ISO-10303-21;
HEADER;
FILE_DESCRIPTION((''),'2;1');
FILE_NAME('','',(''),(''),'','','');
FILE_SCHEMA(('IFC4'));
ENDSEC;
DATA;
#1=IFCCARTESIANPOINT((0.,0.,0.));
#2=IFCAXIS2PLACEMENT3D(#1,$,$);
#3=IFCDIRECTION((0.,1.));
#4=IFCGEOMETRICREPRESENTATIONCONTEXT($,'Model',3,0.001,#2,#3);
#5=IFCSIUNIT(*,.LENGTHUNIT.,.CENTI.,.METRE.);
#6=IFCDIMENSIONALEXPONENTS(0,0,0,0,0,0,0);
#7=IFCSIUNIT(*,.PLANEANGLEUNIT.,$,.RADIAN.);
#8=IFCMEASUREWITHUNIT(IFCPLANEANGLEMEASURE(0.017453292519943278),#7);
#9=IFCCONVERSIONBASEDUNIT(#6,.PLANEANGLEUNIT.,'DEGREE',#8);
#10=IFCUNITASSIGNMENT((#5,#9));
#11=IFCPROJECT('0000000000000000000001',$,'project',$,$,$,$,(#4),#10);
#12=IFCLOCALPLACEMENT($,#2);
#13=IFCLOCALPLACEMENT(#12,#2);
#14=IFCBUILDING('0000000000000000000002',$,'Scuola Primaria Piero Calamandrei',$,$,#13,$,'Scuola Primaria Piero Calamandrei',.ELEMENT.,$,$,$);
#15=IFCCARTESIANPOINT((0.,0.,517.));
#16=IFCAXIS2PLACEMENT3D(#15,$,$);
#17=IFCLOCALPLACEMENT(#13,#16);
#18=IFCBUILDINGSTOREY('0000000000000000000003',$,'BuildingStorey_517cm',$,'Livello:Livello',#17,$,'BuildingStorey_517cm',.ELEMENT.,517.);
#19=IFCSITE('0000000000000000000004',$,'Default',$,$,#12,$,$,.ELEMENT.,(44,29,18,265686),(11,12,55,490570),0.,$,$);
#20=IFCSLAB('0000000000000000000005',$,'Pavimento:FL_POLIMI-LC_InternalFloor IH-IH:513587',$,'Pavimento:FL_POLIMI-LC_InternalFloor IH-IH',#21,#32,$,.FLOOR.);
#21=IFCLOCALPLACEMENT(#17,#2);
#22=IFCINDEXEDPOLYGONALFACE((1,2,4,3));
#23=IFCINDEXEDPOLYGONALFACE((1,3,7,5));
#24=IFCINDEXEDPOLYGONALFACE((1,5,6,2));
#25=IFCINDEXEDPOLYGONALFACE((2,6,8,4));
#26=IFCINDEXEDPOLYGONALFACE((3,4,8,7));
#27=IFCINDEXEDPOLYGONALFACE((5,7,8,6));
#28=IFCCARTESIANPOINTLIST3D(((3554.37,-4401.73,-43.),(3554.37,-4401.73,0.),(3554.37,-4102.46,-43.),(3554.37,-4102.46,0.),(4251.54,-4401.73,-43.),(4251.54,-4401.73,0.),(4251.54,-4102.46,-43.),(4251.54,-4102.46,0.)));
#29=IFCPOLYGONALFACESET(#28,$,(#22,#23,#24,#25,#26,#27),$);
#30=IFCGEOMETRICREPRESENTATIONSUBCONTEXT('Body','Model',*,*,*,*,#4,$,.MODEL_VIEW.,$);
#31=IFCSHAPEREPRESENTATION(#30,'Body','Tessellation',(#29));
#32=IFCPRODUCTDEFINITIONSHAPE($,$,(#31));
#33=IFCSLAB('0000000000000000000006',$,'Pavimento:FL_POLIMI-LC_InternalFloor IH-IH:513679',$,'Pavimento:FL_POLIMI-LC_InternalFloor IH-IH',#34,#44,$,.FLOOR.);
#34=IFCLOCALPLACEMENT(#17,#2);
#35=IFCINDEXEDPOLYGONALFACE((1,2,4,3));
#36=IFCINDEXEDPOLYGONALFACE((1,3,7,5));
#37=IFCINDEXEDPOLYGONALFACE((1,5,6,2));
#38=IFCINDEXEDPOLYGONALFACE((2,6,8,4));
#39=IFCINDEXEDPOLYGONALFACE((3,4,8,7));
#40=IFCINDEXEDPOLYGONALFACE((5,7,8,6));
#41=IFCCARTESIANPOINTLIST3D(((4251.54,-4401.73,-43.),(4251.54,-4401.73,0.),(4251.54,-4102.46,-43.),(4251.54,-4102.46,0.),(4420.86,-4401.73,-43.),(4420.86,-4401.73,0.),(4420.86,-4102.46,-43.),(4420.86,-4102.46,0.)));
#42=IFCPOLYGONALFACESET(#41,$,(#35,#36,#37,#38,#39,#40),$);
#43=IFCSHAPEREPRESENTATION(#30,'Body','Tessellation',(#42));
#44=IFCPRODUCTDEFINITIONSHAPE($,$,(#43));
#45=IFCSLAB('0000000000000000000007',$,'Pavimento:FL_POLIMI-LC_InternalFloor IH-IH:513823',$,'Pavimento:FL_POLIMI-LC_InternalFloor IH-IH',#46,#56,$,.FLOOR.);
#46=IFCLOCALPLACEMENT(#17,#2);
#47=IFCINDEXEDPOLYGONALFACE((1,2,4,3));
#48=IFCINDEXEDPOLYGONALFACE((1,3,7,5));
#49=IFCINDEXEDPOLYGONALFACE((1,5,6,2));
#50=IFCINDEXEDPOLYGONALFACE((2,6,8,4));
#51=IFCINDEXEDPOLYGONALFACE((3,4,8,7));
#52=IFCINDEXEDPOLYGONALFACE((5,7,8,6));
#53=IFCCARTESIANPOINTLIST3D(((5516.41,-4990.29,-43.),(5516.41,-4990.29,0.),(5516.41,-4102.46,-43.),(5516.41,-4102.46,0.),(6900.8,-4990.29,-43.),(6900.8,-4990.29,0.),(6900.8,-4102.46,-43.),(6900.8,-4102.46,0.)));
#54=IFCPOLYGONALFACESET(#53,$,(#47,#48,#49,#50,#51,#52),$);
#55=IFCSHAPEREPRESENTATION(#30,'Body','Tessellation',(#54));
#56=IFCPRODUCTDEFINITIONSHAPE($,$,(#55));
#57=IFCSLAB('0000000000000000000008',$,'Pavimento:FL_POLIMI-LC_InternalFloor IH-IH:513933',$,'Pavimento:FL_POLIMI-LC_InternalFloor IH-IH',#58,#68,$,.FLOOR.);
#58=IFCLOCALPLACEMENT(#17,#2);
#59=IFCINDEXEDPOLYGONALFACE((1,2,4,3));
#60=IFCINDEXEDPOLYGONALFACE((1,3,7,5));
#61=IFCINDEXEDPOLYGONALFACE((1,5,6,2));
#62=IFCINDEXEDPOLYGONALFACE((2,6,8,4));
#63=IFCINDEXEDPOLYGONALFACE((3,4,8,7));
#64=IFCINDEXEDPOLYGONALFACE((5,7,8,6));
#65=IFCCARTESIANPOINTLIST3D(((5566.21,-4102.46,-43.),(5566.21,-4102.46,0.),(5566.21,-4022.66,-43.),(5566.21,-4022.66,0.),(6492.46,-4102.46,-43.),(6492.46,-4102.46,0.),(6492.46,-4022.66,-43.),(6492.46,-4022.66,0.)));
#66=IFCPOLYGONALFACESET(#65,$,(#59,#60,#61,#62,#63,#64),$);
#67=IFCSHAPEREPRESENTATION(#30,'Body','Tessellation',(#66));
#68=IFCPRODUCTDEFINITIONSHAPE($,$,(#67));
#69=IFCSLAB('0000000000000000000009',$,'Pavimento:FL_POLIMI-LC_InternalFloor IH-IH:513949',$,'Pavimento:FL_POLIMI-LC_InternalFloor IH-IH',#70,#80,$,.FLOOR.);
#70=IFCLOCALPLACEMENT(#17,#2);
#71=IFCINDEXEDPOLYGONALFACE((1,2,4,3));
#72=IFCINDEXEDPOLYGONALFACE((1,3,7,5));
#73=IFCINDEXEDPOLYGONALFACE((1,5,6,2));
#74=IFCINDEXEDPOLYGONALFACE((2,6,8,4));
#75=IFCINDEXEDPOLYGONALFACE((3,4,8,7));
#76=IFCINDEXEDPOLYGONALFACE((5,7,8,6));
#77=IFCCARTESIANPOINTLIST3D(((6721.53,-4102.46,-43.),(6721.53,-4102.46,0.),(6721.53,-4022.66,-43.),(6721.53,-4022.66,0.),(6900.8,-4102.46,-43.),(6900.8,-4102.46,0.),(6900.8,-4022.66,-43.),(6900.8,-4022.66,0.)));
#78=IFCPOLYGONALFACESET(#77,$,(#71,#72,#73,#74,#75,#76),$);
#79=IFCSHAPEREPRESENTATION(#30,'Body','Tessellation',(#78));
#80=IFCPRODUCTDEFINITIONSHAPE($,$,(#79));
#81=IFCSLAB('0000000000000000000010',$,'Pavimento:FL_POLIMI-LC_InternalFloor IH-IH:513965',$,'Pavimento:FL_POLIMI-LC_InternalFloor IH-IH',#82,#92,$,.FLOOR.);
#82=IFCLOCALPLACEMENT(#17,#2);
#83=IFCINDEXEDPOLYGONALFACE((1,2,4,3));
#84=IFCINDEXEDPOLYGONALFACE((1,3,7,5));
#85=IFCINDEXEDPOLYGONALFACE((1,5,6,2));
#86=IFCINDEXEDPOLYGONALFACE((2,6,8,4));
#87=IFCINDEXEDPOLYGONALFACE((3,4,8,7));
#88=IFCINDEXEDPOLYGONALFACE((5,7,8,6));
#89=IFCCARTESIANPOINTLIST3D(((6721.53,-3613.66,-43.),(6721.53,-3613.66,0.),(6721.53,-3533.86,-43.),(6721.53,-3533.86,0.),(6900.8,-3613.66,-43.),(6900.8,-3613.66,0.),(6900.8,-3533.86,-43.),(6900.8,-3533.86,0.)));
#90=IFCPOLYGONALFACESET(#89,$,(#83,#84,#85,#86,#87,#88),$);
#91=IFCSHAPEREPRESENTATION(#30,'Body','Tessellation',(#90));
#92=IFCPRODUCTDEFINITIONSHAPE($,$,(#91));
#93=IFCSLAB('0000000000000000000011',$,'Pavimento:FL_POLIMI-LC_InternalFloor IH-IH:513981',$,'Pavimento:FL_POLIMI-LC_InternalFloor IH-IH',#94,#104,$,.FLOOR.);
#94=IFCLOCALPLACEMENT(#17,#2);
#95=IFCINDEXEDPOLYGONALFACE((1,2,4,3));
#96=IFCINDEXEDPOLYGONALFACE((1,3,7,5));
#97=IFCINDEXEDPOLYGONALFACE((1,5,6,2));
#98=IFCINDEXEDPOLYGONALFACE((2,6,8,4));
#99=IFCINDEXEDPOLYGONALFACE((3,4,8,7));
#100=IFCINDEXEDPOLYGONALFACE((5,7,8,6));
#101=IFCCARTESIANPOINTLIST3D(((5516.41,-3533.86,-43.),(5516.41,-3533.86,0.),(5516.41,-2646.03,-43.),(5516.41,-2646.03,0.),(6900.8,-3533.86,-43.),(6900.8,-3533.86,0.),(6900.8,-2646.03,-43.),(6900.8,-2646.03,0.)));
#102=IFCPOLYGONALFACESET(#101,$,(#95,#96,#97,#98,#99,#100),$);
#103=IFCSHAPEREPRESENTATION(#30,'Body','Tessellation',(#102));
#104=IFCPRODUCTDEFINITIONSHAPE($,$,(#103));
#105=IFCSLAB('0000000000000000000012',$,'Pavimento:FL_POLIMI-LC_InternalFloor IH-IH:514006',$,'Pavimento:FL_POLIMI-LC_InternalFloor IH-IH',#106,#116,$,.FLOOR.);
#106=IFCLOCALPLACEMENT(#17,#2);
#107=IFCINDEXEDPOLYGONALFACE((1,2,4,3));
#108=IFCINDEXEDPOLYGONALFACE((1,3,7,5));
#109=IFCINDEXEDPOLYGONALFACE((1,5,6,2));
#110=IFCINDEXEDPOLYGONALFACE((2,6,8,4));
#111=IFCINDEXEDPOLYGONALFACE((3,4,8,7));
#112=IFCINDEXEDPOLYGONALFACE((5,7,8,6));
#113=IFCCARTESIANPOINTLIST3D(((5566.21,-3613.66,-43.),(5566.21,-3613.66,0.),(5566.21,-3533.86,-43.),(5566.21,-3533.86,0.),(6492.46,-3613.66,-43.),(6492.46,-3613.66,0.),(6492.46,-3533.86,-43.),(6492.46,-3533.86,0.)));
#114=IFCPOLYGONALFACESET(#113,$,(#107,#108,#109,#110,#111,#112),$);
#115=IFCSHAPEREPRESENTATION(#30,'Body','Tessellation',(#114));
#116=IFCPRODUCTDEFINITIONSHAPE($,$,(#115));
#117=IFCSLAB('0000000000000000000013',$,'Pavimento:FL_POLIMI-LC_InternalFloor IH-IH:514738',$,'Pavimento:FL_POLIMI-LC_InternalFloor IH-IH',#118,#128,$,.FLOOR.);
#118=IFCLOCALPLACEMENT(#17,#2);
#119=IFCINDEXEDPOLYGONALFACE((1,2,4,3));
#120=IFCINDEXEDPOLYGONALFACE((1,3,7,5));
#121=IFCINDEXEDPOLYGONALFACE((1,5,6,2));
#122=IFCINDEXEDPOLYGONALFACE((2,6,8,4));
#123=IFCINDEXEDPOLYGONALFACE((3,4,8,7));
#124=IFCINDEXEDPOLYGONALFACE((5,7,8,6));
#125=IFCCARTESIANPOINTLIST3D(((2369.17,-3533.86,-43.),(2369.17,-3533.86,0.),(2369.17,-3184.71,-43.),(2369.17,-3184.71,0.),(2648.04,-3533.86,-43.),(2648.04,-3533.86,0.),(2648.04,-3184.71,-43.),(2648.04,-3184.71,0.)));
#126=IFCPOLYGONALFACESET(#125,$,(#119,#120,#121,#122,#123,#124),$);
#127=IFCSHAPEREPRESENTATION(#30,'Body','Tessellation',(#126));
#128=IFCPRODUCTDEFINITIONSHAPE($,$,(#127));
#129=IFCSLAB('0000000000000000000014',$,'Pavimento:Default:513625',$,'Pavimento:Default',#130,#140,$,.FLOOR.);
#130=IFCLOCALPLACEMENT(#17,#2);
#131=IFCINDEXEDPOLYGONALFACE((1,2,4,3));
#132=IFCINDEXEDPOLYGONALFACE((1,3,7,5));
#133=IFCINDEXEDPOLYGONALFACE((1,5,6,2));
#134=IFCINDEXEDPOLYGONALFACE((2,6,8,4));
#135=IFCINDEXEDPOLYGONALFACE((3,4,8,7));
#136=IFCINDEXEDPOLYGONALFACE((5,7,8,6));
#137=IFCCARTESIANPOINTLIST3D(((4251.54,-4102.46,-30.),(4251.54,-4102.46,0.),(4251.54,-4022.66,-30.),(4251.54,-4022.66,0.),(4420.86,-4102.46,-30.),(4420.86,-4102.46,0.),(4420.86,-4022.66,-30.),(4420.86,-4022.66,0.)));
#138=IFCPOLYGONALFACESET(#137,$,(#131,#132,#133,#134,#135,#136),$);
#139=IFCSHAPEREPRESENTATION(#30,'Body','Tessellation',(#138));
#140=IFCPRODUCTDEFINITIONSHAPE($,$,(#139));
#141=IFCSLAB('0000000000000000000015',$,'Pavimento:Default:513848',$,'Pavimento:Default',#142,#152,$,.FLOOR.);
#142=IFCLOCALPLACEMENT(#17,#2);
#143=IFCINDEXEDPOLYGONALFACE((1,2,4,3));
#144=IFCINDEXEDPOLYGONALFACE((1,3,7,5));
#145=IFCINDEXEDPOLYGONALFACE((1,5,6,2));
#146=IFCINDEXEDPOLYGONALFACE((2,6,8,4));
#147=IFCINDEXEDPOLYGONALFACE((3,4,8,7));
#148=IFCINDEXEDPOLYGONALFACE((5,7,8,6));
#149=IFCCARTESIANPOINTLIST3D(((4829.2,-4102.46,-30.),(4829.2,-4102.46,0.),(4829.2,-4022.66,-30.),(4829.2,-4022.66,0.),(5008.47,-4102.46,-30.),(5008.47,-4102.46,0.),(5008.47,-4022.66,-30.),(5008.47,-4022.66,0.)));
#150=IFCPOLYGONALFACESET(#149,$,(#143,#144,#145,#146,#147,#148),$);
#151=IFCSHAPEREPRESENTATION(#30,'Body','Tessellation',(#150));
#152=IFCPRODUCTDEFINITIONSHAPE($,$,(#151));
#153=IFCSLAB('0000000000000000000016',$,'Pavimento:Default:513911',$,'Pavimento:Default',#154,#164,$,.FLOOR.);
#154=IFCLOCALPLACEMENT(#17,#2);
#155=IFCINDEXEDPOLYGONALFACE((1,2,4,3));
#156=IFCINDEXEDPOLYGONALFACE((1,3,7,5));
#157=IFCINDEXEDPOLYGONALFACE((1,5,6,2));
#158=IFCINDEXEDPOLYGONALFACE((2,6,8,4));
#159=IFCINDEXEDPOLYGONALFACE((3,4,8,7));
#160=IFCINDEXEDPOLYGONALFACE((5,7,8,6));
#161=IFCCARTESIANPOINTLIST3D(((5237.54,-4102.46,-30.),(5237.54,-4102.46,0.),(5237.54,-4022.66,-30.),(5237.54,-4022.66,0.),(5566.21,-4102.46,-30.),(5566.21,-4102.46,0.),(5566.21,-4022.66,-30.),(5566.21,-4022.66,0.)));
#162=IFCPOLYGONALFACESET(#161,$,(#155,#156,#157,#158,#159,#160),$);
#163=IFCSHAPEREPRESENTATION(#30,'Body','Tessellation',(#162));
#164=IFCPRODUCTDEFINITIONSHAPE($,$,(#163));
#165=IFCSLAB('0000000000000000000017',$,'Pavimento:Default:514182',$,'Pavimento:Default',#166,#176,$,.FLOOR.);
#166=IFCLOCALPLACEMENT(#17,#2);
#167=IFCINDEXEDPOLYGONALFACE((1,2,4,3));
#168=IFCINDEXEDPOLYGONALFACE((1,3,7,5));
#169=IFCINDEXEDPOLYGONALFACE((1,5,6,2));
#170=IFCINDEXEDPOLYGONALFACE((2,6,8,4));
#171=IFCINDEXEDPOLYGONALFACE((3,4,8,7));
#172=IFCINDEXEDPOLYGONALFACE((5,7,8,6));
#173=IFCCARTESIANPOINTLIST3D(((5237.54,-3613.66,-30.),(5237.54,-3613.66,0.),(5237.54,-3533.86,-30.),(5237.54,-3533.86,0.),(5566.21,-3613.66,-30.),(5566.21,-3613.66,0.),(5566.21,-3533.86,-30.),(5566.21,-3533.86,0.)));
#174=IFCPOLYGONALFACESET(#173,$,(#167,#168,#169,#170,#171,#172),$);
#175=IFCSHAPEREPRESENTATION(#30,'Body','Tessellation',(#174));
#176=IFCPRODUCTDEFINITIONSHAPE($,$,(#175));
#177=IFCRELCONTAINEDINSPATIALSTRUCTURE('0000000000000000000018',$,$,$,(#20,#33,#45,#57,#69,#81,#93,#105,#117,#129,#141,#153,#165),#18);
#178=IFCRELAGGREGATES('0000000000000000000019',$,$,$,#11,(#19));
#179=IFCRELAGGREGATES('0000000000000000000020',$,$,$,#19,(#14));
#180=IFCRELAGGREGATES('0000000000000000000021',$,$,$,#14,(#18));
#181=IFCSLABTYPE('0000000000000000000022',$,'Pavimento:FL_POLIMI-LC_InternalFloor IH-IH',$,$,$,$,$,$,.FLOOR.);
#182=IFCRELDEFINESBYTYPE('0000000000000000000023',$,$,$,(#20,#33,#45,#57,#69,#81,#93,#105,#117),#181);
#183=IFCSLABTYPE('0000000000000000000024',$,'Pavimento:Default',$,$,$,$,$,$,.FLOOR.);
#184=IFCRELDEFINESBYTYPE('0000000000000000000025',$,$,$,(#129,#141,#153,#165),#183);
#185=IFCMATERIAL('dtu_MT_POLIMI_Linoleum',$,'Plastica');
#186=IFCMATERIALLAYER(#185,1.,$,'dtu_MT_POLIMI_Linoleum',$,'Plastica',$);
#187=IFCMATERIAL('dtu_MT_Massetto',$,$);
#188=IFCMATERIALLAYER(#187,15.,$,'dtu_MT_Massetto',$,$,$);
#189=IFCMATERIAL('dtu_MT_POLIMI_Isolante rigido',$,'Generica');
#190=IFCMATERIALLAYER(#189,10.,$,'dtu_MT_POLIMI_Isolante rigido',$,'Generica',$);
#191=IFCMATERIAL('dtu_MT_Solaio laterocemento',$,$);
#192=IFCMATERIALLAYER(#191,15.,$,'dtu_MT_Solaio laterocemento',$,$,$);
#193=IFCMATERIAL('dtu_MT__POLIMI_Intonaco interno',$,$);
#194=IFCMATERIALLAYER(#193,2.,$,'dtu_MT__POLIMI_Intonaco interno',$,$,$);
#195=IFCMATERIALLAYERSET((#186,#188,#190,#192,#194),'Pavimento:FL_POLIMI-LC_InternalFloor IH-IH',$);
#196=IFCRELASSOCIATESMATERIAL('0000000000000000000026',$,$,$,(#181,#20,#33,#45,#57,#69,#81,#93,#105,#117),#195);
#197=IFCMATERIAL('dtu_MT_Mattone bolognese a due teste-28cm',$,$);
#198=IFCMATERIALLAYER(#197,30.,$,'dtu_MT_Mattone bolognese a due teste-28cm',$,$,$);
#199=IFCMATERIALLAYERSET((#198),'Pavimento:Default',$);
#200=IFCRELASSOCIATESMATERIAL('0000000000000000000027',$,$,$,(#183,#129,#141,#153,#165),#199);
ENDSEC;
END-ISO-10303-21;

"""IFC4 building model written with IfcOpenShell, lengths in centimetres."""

from ifc_helpers import new_model, entity, si_unit, converted_unit, direction, frame, frame_2d, origin, origin_2d_with_axis, place, context, subcontext, project, spatial, rectangle, extrude, material, layer, layer_set, layer_usage, type_object, element, save


model = new_model("IFC4")

# Units and contexts
model_context = context("Model", 3, precision=0.001, world=origin(), true_north=direction((0.0, 1.0)))
body_context = subcontext(model_context, "Body", "Model", "MODEL_VIEW")
ifc_project = project(units=[si_unit("LENGTHUNIT", "METRE", prefix="CENTI"), converted_unit("PLANEANGLEUNIT", "DEGREE", entity("IfcPlaneAngleMeasure", 0.017453292519943278), si_unit("PLANEANGLEUNIT", "RADIAN"), dimensions=[0, 0, 0, 0, 0, 0, 0])], contexts=[model_context])

# Site, building, storey
site_placement = place(None, origin())
site = spatial("IfcSite", under=ifc_project, at=site_placement, Name="Default", CompositionType="ELEMENT", RefLatitude=(44, 29, 18, 265686), RefLongitude=(11, 12, 55, 490570), RefElevation=0.0)
building_placement = place(site_placement, origin())
building = spatial("IfcBuilding", under=site, at=building_placement, Name="Scuola Primaria Piero Calamandrei", LongName="Scuola Primaria Piero Calamandrei", CompositionType="ELEMENT")
storey_placement = place(building_placement, frame((0.0, 0.0, 517.0)))
storey = spatial("IfcBuildingStorey", under=building, at=storey_placement, Name="BuildingStorey_517cm", ObjectType="Livello:Livello", LongName="BuildingStorey_517cm", CompositionType="ELEMENT", Elevation=517.0)

# Slabs
ifc_material_1 = material(Name="dtu_MT_POLIMI_Linoleum", Category="Plastica")
ifc_layer_1 = layer(ifc_material_1, 1.0, Name="dtu_MT_POLIMI_Linoleum", Category="Plastica")
ifc_material_2 = material(Name="dtu_MT_Massetto")
ifc_layer_2 = layer(ifc_material_2, 15.0, Name="dtu_MT_Massetto")
ifc_material_3 = material(Name="dtu_MT_POLIMI_Isolante rigido", Category="Generica")
ifc_layer_3 = layer(ifc_material_3, 10.0, Name="dtu_MT_POLIMI_Isolante rigido", Category="Generica")
ifc_material_4 = material(Name="dtu_MT_Solaio laterocemento")
ifc_layer_4 = layer(ifc_material_4, 15.0, Name="dtu_MT_Solaio laterocemento")
ifc_material_5 = material(Name="dtu_MT__POLIMI_Intonaco interno")
ifc_layer_5 = layer(ifc_material_5, 2.0, Name="dtu_MT__POLIMI_Intonaco interno")
ifc_layer_set_1 = layer_set([ifc_layer_1, ifc_layer_2, ifc_layer_3, ifc_layer_4, ifc_layer_5], Name="Pavimento:FL_POLIMI-LC_InternalFloor IH-IH")
ifc_layer_usage_1 = layer_usage(ifc_layer_set_1, "AXIS3", "POSITIVE", 0.0)
slab_type_1 = type_object("IfcSlabType", Name="Pavimento:FL_POLIMI-LC_InternalFloor IH-IH", PredefinedType="FLOOR", material=ifc_layer_set_1)
slab_1_placement = place(storey_placement, origin())
element("IfcSlab", 1, at=slab_1_placement, inside=storey, type_object=slab_type_1, material=ifc_layer_usage_1, Name="Pavimento:FL_POLIMI-LC_InternalFloor IH-IH:513587", ObjectType="Pavimento:FL_POLIMI-LC_InternalFloor IH-IH", PredefinedType="FLOOR", context=body_context, shape_type="SweptSolid", body=[
    extrude(rectangle(XDim=299.27, YDim=697.17, at=frame_2d((0.0, 0.0), x_axis=(1.0, 0.0))), frame((3902.96, -4252.1, 0.0), z_axis=(0.0, 0.0, -1.0), x_axis=(0.0, 1.0, 0.0)), (0.0, 0.0, 1.0), 43.0),
])
ifc_layer_usage_2 = layer_usage(ifc_layer_set_1, "AXIS3", "POSITIVE", 0.0)
slab_2_placement = place(storey_placement, origin())
element("IfcSlab", 2, at=slab_2_placement, inside=storey, type_object=slab_type_1, material=ifc_layer_usage_2, Name="Pavimento:FL_POLIMI-LC_InternalFloor IH-IH:513679", ObjectType="Pavimento:FL_POLIMI-LC_InternalFloor IH-IH", PredefinedType="FLOOR", context=body_context, shape_type="SweptSolid", body=[
    extrude(rectangle(XDim=299.27, YDim=169.31, at=origin_2d_with_axis()), frame((4336.2, -4252.1, 0.0), z_axis=(0.0, 0.0, -1.0), x_axis=(0.0, 1.0, 0.0)), (0.0, 0.0, 1.0), 43.0),
])
ifc_layer_usage_3 = layer_usage(ifc_layer_set_1, "AXIS3", "POSITIVE", 0.0)
slab_3_placement = place(storey_placement, origin())
element("IfcSlab", 3, at=slab_3_placement, inside=storey, type_object=slab_type_1, material=ifc_layer_usage_3, Name="Pavimento:FL_POLIMI-LC_InternalFloor IH-IH:513823", ObjectType="Pavimento:FL_POLIMI-LC_InternalFloor IH-IH", PredefinedType="FLOOR", context=body_context, shape_type="SweptSolid", body=[
    extrude(rectangle(XDim=887.82, YDim=1384.39, at=frame_2d((0.0, 0.0), x_axis=(1.0, 0.0))), frame((6208.61, -4546.38, 0.0), z_axis=(0.0, 0.0, -1.0), x_axis=(0.0, 1.0, 0.0)), (0.0, 0.0, 1.0), 43.0),
])
ifc_layer_usage_4 = layer_usage(ifc_layer_set_1, "AXIS3", "POSITIVE", 0.0)
slab_4_placement = place(storey_placement, origin())
element("IfcSlab", 4, at=slab_4_placement, inside=storey, type_object=slab_type_1, material=ifc_layer_usage_4, Name="Pavimento:FL_POLIMI-LC_InternalFloor IH-IH:513933", ObjectType="Pavimento:FL_POLIMI-LC_InternalFloor IH-IH", PredefinedType="FLOOR", context=body_context, shape_type="SweptSolid", body=[
    extrude(rectangle(XDim=79.8, YDim=926.24, at=frame_2d((0.0, 0.0), x_axis=(1.0, 0.0))), frame((6029.33, -4062.56, 0.0), z_axis=(0.0, 0.0, -1.0), x_axis=(0.0, 1.0, 0.0)), (0.0, 0.0, 1.0), 43.0),
])
ifc_layer_usage_5 = layer_usage(ifc_layer_set_1, "AXIS3", "POSITIVE", 0.0)
slab_5_placement = place(storey_placement, origin())
element("IfcSlab", 5, at=slab_5_placement, inside=storey, type_object=slab_type_1, material=ifc_layer_usage_5, Name="Pavimento:FL_POLIMI-LC_InternalFloor IH-IH:513949", ObjectType="Pavimento:FL_POLIMI-LC_InternalFloor IH-IH", PredefinedType="FLOOR", context=body_context, shape_type="SweptSolid", body=[
    extrude(rectangle(XDim=79.8, YDim=179.27, at=frame_2d((0.0, 0.0), x_axis=(1.0, 0.0))), frame((6811.16, -4062.56, 0.0), z_axis=(0.0, 0.0, -1.0), x_axis=(0.0, 1.0, 0.0)), (0.0, 0.0, 1.0), 43.0),
])
ifc_layer_usage_6 = layer_usage(ifc_layer_set_1, "AXIS3", "POSITIVE", 0.0)
slab_6_placement = place(storey_placement, origin())
element("IfcSlab", 6, at=slab_6_placement, inside=storey, type_object=slab_type_1, material=ifc_layer_usage_6, Name="Pavimento:FL_POLIMI-LC_InternalFloor IH-IH:513965", ObjectType="Pavimento:FL_POLIMI-LC_InternalFloor IH-IH", PredefinedType="FLOOR", context=body_context, shape_type="SweptSolid", body=[
    extrude(rectangle(XDim=79.8, YDim=179.27, at=frame_2d((0.0, 0.0), x_axis=(1.0, 0.0))), frame((6811.16, -3573.76, 0.0), z_axis=(0.0, 0.0, -1.0), x_axis=(0.0, 1.0, 0.0)), (0.0, 0.0, 1.0), 43.0),
])
ifc_layer_usage_7 = layer_usage(ifc_layer_set_1, "AXIS3", "POSITIVE", 0.0)
slab_7_placement = place(storey_placement, origin())
element("IfcSlab", 7, at=slab_7_placement, inside=storey, type_object=slab_type_1, material=ifc_layer_usage_7, Name="Pavimento:FL_POLIMI-LC_InternalFloor IH-IH:513981", ObjectType="Pavimento:FL_POLIMI-LC_InternalFloor IH-IH", PredefinedType="FLOOR", context=body_context, shape_type="SweptSolid", body=[
    extrude(rectangle(XDim=887.82, YDim=1384.39, at=frame_2d((0.0, 0.0), x_axis=(1.0, 0.0))), frame((6208.61, -3089.94, 0.0), z_axis=(0.0, 0.0, -1.0), x_axis=(0.0, 1.0, 0.0)), (0.0, 0.0, 1.0), 43.0),
])
ifc_layer_usage_8 = layer_usage(ifc_layer_set_1, "AXIS3", "POSITIVE", 0.0)
slab_8_placement = place(storey_placement, origin())
element("IfcSlab", 8, at=slab_8_placement, inside=storey, type_object=slab_type_1, material=ifc_layer_usage_8, Name="Pavimento:FL_POLIMI-LC_InternalFloor IH-IH:514006", ObjectType="Pavimento:FL_POLIMI-LC_InternalFloor IH-IH", PredefinedType="FLOOR", context=body_context, shape_type="SweptSolid", body=[
    extrude(rectangle(XDim=79.8, YDim=926.24, at=frame_2d((0.0, 0.0), x_axis=(1.0, 0.0))), frame((6029.33, -3573.76, 0.0), z_axis=(0.0, 0.0, -1.0), x_axis=(0.0, 1.0, 0.0)), (0.0, 0.0, 1.0), 43.0),
])
ifc_layer_usage_9 = layer_usage(ifc_layer_set_1, "AXIS3", "POSITIVE", 0.0)
slab_9_placement = place(storey_placement, origin())
element("IfcSlab", 9, at=slab_9_placement, inside=storey, type_object=slab_type_1, material=ifc_layer_usage_9, Name="Pavimento:FL_POLIMI-LC_InternalFloor IH-IH:514738", ObjectType="Pavimento:FL_POLIMI-LC_InternalFloor IH-IH", PredefinedType="FLOOR", context=body_context, shape_type="SweptSolid", body=[
    extrude(rectangle(XDim=349.14, YDim=278.87, at=origin_2d_with_axis()), frame((2508.61, -3359.28, 0.0), z_axis=(0.0, 0.0, -1.0), x_axis=(0.0, 1.0, 0.0)), (0.0, 0.0, 1.0), 43.0),
])
ifc_material_6 = material(Name="dtu_MT_Mattone bolognese a due teste-28cm")
ifc_layer_6 = layer(ifc_material_6, 30.0, Name="dtu_MT_Mattone bolognese a due teste-28cm")
ifc_layer_set_2 = layer_set([ifc_layer_6], Name="Pavimento:Default")
ifc_layer_usage_10 = layer_usage(ifc_layer_set_2, "AXIS3", "POSITIVE", 0.0)
slab_type_2 = type_object("IfcSlabType", Name="Pavimento:Default", PredefinedType="FLOOR", material=ifc_layer_set_2)
slab_10_placement = place(storey_placement, origin())
element("IfcSlab", 10, at=slab_10_placement, inside=storey, type_object=slab_type_2, material=ifc_layer_usage_10, Name="Pavimento:Default:513625", ObjectType="Pavimento:Default", PredefinedType="FLOOR", context=body_context, shape_type="SweptSolid", body=[
    extrude(rectangle(XDim=79.8, YDim=169.31, at=frame_2d((0.0, 0.0), x_axis=(1.0, 0.0))), frame((4336.2, -4062.56, 0.0), z_axis=(0.0, 0.0, -1.0), x_axis=(0.0, 1.0, 0.0)), (0.0, 0.0, 1.0), 30.0),
])
ifc_layer_usage_11 = layer_usage(ifc_layer_set_2, "AXIS3", "POSITIVE", 0.0)
slab_11_placement = place(storey_placement, origin())
element("IfcSlab", 11, at=slab_11_placement, inside=storey, type_object=slab_type_2, material=ifc_layer_usage_11, Name="Pavimento:Default:513848", ObjectType="Pavimento:Default", PredefinedType="FLOOR", context=body_context, shape_type="SweptSolid", body=[
    extrude(rectangle(XDim=79.8, YDim=179.27, at=frame_2d((0.0, 0.0), x_axis=(1.0, 0.0))), frame((4918.84, -4062.56, 0.0), z_axis=(0.0, 0.0, -1.0), x_axis=(0.0, 1.0, 0.0)), (0.0, 0.0, 1.0), 30.0),
])
ifc_layer_usage_12 = layer_usage(ifc_layer_set_2, "AXIS3", "POSITIVE", 0.0)
slab_12_placement = place(storey_placement, origin())
element("IfcSlab", 12, at=slab_12_placement, inside=storey, type_object=slab_type_2, material=ifc_layer_usage_12, Name="Pavimento:Default:513911", ObjectType="Pavimento:Default", PredefinedType="FLOOR", context=body_context, shape_type="SweptSolid", body=[
    extrude(rectangle(XDim=79.8, YDim=328.67, at=frame_2d((0.0, 0.0), x_axis=(1.0, 0.0))), frame((5401.88, -4062.56, 0.0), z_axis=(0.0, 0.0, -1.0), x_axis=(0.0, 1.0, 0.0)), (0.0, 0.0, 1.0), 30.0),
])
ifc_layer_usage_13 = layer_usage(ifc_layer_set_2, "AXIS3", "POSITIVE", 0.0)
slab_13_placement = place(storey_placement, origin())
element("IfcSlab", 13, at=slab_13_placement, inside=storey, type_object=slab_type_2, material=ifc_layer_usage_13, Name="Pavimento:Default:514182", ObjectType="Pavimento:Default", PredefinedType="FLOOR", context=body_context, shape_type="SweptSolid", body=[
    extrude(rectangle(XDim=79.8, YDim=328.67, at=origin_2d_with_axis()), frame((5401.88, -3573.76, 0.0), z_axis=(0.0, 0.0, -1.0), x_axis=(0.0, 1.0, 0.0)), (0.0, 0.0, 1.0), 30.0),
])

save(model, "model.ifc")
